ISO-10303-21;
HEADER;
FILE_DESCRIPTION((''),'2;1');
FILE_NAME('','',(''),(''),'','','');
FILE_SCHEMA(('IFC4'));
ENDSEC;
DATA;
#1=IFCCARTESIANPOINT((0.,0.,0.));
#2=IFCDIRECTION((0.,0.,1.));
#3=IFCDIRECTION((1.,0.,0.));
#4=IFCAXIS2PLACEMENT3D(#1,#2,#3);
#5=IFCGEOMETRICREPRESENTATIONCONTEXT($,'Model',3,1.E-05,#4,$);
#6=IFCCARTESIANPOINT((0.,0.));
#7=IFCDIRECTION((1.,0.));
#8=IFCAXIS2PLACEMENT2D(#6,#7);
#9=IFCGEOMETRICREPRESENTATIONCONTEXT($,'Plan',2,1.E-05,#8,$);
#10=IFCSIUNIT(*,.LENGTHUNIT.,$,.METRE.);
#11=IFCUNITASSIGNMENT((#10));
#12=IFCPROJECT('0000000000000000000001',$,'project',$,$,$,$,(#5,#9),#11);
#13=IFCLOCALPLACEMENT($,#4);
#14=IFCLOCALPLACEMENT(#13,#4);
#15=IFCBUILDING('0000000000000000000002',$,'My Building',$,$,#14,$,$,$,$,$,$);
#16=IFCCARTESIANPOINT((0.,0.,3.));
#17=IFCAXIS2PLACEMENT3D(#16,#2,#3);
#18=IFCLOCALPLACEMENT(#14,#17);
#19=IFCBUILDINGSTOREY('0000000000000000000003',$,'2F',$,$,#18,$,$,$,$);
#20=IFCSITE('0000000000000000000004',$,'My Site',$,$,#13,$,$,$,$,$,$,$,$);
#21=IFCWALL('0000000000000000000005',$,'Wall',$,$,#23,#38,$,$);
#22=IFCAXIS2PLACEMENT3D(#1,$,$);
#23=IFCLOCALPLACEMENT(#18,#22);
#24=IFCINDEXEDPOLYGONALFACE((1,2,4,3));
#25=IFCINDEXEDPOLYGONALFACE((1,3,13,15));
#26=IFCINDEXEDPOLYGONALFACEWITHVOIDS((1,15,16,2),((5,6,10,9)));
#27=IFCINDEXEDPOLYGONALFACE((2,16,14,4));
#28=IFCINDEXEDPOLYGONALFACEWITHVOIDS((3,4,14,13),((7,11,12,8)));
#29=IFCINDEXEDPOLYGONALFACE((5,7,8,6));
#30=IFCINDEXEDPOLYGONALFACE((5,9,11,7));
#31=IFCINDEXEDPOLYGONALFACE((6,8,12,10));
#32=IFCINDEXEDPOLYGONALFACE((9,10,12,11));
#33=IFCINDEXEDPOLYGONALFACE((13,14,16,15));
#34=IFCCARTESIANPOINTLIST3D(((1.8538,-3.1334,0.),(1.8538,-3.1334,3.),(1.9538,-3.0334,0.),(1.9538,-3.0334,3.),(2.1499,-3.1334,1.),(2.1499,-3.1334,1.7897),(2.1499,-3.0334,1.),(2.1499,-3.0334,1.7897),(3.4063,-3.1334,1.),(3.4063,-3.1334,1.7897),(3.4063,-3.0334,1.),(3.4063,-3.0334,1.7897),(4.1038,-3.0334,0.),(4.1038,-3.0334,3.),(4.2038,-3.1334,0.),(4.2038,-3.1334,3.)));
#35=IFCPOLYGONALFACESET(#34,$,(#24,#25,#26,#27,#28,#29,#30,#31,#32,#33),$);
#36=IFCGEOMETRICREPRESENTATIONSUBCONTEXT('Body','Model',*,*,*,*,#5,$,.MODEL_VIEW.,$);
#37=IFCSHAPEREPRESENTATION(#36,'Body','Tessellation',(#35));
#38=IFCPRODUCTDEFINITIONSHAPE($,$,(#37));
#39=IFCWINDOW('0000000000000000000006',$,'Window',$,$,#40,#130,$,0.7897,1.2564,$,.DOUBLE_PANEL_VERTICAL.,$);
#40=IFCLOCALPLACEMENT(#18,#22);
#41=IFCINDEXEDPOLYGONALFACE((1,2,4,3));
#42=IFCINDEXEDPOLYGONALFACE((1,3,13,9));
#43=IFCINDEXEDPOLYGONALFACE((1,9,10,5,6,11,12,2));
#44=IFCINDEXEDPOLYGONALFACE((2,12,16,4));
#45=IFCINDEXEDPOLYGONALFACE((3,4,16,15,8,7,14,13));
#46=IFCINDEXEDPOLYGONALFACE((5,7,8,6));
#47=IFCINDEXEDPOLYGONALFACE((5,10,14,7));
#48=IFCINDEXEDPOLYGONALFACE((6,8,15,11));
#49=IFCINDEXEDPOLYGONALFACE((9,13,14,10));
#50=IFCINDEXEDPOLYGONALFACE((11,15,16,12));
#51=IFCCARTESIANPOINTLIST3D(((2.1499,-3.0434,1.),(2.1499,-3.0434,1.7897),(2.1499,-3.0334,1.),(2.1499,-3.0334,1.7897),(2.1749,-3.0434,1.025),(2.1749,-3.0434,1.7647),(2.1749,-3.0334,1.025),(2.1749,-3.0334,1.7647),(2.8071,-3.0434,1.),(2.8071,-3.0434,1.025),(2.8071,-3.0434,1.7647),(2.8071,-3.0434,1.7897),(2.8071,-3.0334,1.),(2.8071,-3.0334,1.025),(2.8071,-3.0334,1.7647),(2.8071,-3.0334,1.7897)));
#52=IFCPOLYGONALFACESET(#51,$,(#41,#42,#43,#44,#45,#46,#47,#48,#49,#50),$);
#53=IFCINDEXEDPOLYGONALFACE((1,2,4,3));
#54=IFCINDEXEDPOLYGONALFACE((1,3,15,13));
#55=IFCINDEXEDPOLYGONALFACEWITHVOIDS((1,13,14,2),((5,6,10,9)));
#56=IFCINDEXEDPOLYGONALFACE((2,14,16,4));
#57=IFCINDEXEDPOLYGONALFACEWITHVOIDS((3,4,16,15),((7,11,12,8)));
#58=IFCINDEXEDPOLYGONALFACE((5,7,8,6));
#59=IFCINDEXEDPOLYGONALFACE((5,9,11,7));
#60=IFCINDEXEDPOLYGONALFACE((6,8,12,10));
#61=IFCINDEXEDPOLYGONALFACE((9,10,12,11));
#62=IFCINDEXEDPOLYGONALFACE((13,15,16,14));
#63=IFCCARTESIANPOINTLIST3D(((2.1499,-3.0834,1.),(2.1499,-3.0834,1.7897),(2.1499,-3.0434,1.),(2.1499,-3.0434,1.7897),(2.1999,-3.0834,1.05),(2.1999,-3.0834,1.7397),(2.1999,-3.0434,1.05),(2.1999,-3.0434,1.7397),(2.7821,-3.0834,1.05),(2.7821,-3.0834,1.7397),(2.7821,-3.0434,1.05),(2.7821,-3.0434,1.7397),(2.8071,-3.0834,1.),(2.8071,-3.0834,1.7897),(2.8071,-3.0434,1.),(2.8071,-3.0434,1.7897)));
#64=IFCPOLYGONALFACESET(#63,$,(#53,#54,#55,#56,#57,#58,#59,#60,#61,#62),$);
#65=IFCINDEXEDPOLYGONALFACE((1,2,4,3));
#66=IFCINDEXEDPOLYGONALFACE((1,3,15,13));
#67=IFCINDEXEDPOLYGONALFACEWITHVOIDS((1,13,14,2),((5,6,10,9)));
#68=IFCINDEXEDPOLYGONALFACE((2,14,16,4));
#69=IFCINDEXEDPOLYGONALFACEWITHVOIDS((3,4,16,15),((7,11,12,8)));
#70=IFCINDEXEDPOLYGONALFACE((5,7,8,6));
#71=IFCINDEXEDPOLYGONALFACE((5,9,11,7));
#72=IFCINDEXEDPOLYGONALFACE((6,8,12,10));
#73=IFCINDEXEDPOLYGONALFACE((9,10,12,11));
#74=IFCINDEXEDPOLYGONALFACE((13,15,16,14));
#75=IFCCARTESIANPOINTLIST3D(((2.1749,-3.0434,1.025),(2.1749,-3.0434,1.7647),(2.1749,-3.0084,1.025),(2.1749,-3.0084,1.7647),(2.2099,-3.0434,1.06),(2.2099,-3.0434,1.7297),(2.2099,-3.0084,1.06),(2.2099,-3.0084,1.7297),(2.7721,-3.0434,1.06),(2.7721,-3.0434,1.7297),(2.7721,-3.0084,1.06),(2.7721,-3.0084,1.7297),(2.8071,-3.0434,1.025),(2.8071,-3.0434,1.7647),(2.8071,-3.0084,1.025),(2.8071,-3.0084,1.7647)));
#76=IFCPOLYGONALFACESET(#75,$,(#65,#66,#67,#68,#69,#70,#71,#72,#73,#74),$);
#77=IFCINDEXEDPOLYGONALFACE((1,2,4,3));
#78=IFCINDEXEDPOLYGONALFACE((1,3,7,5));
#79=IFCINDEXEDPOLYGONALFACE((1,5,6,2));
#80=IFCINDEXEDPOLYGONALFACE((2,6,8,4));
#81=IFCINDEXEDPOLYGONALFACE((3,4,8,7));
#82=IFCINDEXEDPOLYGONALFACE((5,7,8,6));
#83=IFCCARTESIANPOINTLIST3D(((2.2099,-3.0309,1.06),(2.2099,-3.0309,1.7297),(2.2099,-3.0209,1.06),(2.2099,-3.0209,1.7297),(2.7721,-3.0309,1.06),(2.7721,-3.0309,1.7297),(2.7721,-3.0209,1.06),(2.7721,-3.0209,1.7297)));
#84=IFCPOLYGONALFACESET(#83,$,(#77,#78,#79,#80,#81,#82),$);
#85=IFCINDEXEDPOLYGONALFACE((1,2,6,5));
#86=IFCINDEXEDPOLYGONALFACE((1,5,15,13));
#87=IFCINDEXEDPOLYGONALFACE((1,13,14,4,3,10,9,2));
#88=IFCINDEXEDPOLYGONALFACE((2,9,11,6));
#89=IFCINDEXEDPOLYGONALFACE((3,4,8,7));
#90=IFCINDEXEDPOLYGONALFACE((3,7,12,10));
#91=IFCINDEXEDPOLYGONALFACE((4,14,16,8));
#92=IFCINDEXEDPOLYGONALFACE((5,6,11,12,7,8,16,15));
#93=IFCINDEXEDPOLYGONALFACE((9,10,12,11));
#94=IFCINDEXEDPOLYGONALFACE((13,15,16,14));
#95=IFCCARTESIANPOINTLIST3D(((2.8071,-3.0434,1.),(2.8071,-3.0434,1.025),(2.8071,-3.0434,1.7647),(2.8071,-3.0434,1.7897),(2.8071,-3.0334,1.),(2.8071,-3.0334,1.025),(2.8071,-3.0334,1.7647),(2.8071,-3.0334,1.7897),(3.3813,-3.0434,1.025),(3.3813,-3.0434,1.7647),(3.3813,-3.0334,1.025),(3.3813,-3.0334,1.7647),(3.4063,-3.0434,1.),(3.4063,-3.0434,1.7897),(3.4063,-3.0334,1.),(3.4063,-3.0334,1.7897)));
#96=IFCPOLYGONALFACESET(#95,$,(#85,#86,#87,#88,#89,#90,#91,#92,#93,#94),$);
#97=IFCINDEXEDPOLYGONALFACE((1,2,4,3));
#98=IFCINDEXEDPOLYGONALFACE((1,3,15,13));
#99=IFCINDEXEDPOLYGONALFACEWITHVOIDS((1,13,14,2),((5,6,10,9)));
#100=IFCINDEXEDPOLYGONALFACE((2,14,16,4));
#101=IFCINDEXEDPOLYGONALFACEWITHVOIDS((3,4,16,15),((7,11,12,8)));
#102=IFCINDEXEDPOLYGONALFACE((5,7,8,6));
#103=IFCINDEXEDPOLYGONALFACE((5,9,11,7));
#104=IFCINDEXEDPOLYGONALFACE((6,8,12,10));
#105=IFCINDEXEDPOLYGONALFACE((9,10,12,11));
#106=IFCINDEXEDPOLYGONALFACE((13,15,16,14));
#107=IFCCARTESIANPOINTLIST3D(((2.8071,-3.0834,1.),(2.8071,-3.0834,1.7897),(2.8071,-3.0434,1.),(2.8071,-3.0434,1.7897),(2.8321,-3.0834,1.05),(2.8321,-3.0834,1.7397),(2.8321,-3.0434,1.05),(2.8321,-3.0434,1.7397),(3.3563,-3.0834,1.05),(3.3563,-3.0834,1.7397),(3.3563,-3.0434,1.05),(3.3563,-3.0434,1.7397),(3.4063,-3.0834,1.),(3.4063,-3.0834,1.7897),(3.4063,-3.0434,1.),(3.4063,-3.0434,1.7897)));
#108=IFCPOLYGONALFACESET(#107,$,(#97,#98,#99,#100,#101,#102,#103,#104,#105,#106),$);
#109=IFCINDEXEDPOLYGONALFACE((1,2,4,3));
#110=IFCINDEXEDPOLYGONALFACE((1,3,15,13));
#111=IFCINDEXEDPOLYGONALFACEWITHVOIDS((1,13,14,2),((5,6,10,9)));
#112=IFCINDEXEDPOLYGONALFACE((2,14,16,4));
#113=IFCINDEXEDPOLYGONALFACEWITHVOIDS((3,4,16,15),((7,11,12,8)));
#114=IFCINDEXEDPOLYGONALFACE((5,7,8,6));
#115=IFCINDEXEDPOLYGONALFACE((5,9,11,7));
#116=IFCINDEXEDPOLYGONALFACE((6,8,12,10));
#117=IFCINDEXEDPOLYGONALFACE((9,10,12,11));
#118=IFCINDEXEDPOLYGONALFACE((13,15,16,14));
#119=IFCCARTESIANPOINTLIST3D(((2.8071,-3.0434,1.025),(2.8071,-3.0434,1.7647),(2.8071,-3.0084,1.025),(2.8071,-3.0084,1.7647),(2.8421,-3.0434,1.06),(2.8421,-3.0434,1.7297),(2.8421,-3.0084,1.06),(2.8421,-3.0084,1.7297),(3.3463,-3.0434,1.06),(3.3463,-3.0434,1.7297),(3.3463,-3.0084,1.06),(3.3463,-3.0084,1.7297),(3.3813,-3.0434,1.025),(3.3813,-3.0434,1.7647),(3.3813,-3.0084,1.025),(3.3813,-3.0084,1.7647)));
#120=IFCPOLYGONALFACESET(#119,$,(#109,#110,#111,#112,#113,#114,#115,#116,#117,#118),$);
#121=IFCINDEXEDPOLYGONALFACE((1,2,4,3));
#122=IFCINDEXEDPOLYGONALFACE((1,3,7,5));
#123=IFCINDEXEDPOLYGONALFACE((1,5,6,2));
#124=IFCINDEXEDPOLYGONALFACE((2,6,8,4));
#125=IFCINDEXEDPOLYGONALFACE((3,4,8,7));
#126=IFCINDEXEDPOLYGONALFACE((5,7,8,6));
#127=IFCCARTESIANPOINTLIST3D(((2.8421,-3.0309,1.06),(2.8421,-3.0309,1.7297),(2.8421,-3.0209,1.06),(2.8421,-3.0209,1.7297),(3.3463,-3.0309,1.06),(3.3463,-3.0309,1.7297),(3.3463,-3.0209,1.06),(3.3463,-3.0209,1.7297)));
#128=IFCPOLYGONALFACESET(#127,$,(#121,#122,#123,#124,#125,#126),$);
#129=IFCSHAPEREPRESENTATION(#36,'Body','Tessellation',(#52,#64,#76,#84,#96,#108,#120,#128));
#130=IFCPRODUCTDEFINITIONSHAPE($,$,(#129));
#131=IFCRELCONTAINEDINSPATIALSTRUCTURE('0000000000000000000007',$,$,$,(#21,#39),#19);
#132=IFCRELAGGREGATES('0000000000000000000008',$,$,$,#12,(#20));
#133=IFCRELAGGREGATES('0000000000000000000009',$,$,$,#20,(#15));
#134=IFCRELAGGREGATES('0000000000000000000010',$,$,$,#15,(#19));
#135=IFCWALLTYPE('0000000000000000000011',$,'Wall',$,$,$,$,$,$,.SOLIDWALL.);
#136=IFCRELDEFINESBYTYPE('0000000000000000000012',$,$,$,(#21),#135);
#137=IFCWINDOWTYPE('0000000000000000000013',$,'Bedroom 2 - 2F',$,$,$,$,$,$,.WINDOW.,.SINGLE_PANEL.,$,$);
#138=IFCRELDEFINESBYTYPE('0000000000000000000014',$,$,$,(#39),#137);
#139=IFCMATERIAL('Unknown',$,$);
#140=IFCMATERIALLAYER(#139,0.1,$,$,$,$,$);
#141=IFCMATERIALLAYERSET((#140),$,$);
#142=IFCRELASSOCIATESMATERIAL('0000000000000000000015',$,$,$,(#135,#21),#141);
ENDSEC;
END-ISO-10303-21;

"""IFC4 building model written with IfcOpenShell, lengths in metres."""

from ifc_helpers import new_model, entity, si_unit, frame, origin_with_axes, origin_2d_with_axis, place, context, subcontext, project, spatial, line, indexed_curve, outline, extrude, shape, source, transform, mapped, material, layer, layer_set, layer_usage, type_object, type_shapes, element, fill, save


model = new_model("IFC4")

# Units and contexts
model_context = context("Model", 3, precision=1e-05, world=origin_with_axes())
plan_context = context("Plan", 2, precision=1e-05, world=origin_2d_with_axis())
body_context_1 = subcontext(model_context, "Body", "Model", "MODEL_VIEW")
body_context_2 = subcontext(plan_context, "Body", "Plan", "PLAN_VIEW")
ifc_project = project(units=[si_unit("LENGTHUNIT", "METRE")], contexts=[model_context, plan_context])

# Site, building, storey
site_placement = place(None, origin_with_axes())
site = spatial("IfcSite", under=ifc_project, at=site_placement, Name="My Site")
building_placement = place(site_placement, origin_with_axes())
building = spatial("IfcBuilding", under=site, at=building_placement, Name="My Building")
storey_placement = place(building_placement, frame((0.0, 0.0, 3.0), z_axis=(0.0, 0.0, 1.0), x_axis=(1.0, 0.0, 0.0)))
storey = spatial("IfcBuildingStorey", under=building, at=storey_placement, Name="2F")

# Shared definitions
ifc_material = material(Name="Unknown")

# Shared definitions
ifc_layer_1 = layer(ifc_material, 0.1)
ifc_layer_set_1 = layer_set([ifc_layer_1])
wall_type = type_object("IfcWallType", Name="Wall", PredefinedType="SOLIDWALL", material=ifc_layer_set_1)

# Wall, opening, window
ifc_layer_usage_1 = layer_usage(ifc_layer_set_1, "AXIS2", "POSITIVE", 0.0)
wall_1_placement = place(storey_placement, frame((1.8538, -3.1334, 0.0), z_axis=(0.0, 0.0, 1.0), x_axis=(1.0, 0.0, 0.0)))
wall_1 = element("IfcWall", 1, at=wall_1_placement, inside=storey, type_object=wall_type, material=ifc_layer_usage_1, Name="Wall", context=body_context_1, shape_type="SweptSolid", body=[
    extrude(outline(indexed_curve([(0.0, 0.0), (0.1, 0.1), (2.25, 0.1), (2.35, 0.0)], segments=[line(1, 2, 3, 4, 1)])), origin_with_axes(), (0.0, 0.0, 1.0), 3.0),
])
shared_shape_1 = source(origin_with_axes(), body_context_1, "Body", "SweptSolid", [
    extrude(outline(indexed_curve([(0.0, 0.0), (1.2564, 0.0), (1.2564, 0.7897), (0.0, 0.7897)], segments=[line(1, 2, 3, 4, 1)])), frame((0.0, -0.6, 0.0), z_axis=(0.0, -1.0, 0.0), x_axis=(1.0, 0.0, 0.0)), (0.0, 0.0, -1.0), 1.2),
])
opening_1_placement = place(wall_1_placement, frame((0.296, 0.0, 1.0), z_axis=(0.0, 0.0, 1.0), x_axis=(1.0, 0.0, 0.0)))
opening_1 = element("IfcOpeningElement", 2, at=opening_1_placement, cuts=wall_1, PredefinedType="OPENING", context=body_context_1, shape_type="MappedRepresentation", body=[
    mapped(shared_shape_1, transform((0.0, 0.0, 0.0), x_axis=(1.0, 0.0, 0.0), y_axis=(0.0, 1.0, 0.0), z_axis=(0.0, 0.0, 1.0), scale=1.0)),
])
window_type_1 = type_object("IfcWindowType", Name="Bedroom 2 - 2F", PartitioningType="SINGLE_PANEL", PredefinedType="WINDOW")
shared_shape_2 = source(origin_with_axes(), body_context_1, "Body", "SweptSolid", [
    extrude(outline(indexed_curve([(0.6572, 0.0), (0.0, 0.0), (0.0, 0.7897), (0.6572, 0.7897), (0.6572, 0.7647), (0.025, 0.7647), (0.025, 0.025), (0.6572, 0.025)], segments=[line(1, 2, 3, 4, 5, 6, 7, 8, 1)])), frame((0.0, 0.09, 0.0), z_axis=(0.0, -1.0, 0.0), x_axis=(1.0, 0.0, 0.0)), (0.0, 0.0, -1.0), 0.01),
    extrude(outline(indexed_curve([(0.0, 0.0), (0.6572, 0.0), (0.6572, 0.7897), (0.0, 0.7897)], segments=[line(1, 2, 3, 4, 1)]), holes=[indexed_curve([(0.05, 0.05), (0.6322, 0.05), (0.6322, 0.7397), (0.05, 0.7397)], segments=[line(1, 2, 3, 4, 1)])]), frame((0.0, 0.05, 0.0), z_axis=(0.0, -1.0, 0.0), x_axis=(1.0, 0.0, 0.0)), (0.0, 0.0, -1.0), 0.04),
    extrude(outline(indexed_curve([(0.0, 0.0), (0.6322, 0.0), (0.6322, 0.7397), (0.0, 0.7397)], segments=[line(1, 2, 3, 4, 1)]), holes=[indexed_curve([(0.035, 0.035), (0.5972, 0.035), (0.5972, 0.7047), (0.035, 0.7047)], segments=[line(1, 2, 3, 4, 1)])]), frame((0.025, 0.09, 0.025), z_axis=(0.0, -1.0, 0.0), x_axis=(1.0, 0.0, 0.0)), (0.0, 0.0, -1.0), 0.035),
    extrude(outline(indexed_curve([(0.035, 0.035), (0.5972, 0.035), (0.5972, 0.7047), (0.035, 0.7047)], segments=[line(1, 2, 3, 4, 1)])), frame((0.025, 0.1025, 0.025), z_axis=(0.0, -1.0, 0.0), x_axis=(1.0, 0.0, 0.0)), (0.0, 0.0, -1.0), 0.01),
    extrude(outline(indexed_curve([(0.0, 0.7897), (0.5992, 0.7897), (0.5992, 0.0), (0.0, 0.0), (0.0, 0.025), (0.5742, 0.025), (0.5742, 0.7647), (0.0, 0.7647)], segments=[line(1, 2, 3, 4, 5, 6, 7, 8, 1)])), frame((0.6572, 0.09, 0.0), z_axis=(0.0, -1.0, 0.0), x_axis=(1.0, 0.0, 0.0)), (0.0, 0.0, -1.0), 0.01),
    extrude(outline(indexed_curve([(0.0, 0.0), (0.5992, 0.0), (0.5992, 0.7897), (0.0, 0.7897)], segments=[line(1, 2, 3, 4, 1)]), holes=[indexed_curve([(0.025, 0.05), (0.5492, 0.05), (0.5492, 0.7397), (0.025, 0.7397)], segments=[line(1, 2, 3, 4, 1)])]), frame((0.6572, 0.05, 0.0), z_axis=(0.0, -1.0, 0.0), x_axis=(1.0, 0.0, 0.0)), (0.0, 0.0, -1.0), 0.04),
    extrude(outline(indexed_curve([(0.0, 0.0), (0.5742, 0.0), (0.5742, 0.7397), (0.0, 0.7397)], segments=[line(1, 2, 3, 4, 1)]), holes=[indexed_curve([(0.035, 0.035), (0.5392, 0.035), (0.5392, 0.7047), (0.035, 0.7047)], segments=[line(1, 2, 3, 4, 1)])]), frame((0.6572, 0.09, 0.025), z_axis=(0.0, -1.0, 0.0), x_axis=(1.0, 0.0, 0.0)), (0.0, 0.0, -1.0), 0.035),
    extrude(outline(indexed_curve([(0.035, 0.035), (0.5392, 0.035), (0.5392, 0.7047), (0.035, 0.7047)], segments=[line(1, 2, 3, 4, 1)])), frame((0.6572, 0.1025, 0.025), z_axis=(0.0, -1.0, 0.0), x_axis=(1.0, 0.0, 0.0)), (0.0, 0.0, -1.0), 0.01),
])
shared_shape_3 = source(origin_with_axes(), body_context_2, "Body", "Curve2D", [
    entity("IfcIndexedPolyCurve", entity("IfcCartesianPointList2D", [[0.05, 0.05], [0.6322, 0.05]])),
    entity("IfcIndexedPolyCurve", entity("IfcCartesianPointList2D", [[0.0, 0.1], [0.025, 0.1], [0.025, 0.09], [0.05, 0.09], [0.05, 0.05], [0.0, 0.05]]), [entity("IfcLineIndex", [1, 2, 3, 4, 5, 6, 1])]),
    entity("IfcIndexedPolyCurve", entity("IfcCartesianPointList2D", [[0.6572, 0.1], [0.6572, 0.1], [0.6572, 0.09], [0.6322, 0.09], [0.6322, 0.05], [0.6572, 0.05]])),
    entity("IfcIndexedPolyCurve", entity("IfcCartesianPointList2D", [[0.025, 0.09], [0.06, 0.09], [0.06, 0.125], [0.025, 0.125]]), [entity("IfcLineIndex", [1, 2, 3, 4, 1])]),
    entity("IfcIndexedPolyCurve", entity("IfcCartesianPointList2D", [[0.6572, 0.09], [0.6222, 0.09], [0.6222, 0.125], [0.6572, 0.125]]), [entity("IfcLineIndex", [1, 2, 3, 4, 1])]),
    entity("IfcIndexedPolyCurve", entity("IfcCartesianPointList2D", [[0.06, 0.09], [0.6222, 0.09]])),
    entity("IfcIndexedPolyCurve", entity("IfcCartesianPointList2D", [[0.06, 0.125], [0.6222, 0.125]])),
    entity("IfcIndexedPolyCurve", entity("IfcCartesianPointList2D", [[0.06, 0.1075], [0.6222, 0.1075]])),
    entity("IfcIndexedPolyCurve", entity("IfcCartesianPointList2D", [[0.6822, 0.05], [1.2064, 0.05]])),
    entity("IfcIndexedPolyCurve", entity("IfcCartesianPointList2D", [[0.6572, 0.1], [0.6572, 0.1], [0.6572, 0.09], [0.6822, 0.09], [0.6822, 0.05], [0.6572, 0.05]])),
    entity("IfcIndexedPolyCurve", entity("IfcCartesianPointList2D", [[1.2564, 0.1], [1.2314, 0.1], [1.2314, 0.09], [1.2064, 0.09], [1.2064, 0.05], [1.2564, 0.05]]), [entity("IfcLineIndex", [1, 2, 3, 4, 5, 6, 1])]),
    entity("IfcIndexedPolyCurve", entity("IfcCartesianPointList2D", [[0.6572, 0.09], [0.6922, 0.09], [0.6922, 0.125], [0.6572, 0.125]]), [entity("IfcLineIndex", [1, 2, 3, 4, 1])]),
    entity("IfcIndexedPolyCurve", entity("IfcCartesianPointList2D", [[1.2314, 0.09], [1.1964, 0.09], [1.1964, 0.125], [1.2314, 0.125]]), [entity("IfcLineIndex", [1, 2, 3, 4, 1])]),
    entity("IfcIndexedPolyCurve", entity("IfcCartesianPointList2D", [[0.6922, 0.09], [1.1964, 0.09]])),
    entity("IfcIndexedPolyCurve", entity("IfcCartesianPointList2D", [[0.6922, 0.125], [1.1964, 0.125]])),
    entity("IfcIndexedPolyCurve", entity("IfcCartesianPointList2D", [[0.6922, 0.1075], [1.1964, 0.1075]])),
])
type_shapes(window_type_1, [shared_shape_2, shared_shape_3])
window_1_placement = place(opening_1_placement, frame((0.0, 0.0, 0.0), z_axis=(0.0, 0.0, 1.0), x_axis=(1.0, 0.0, 0.0)))
window_1 = element("IfcWindow", 3, at=window_1_placement, inside=storey, type_object=window_type_1, Name="Window", OverallHeight=0.7897, OverallWidth=1.2564, PartitioningType="DOUBLE_PANEL_VERTICAL", shapes=[
    shape(body_context_1, "Body", "MappedRepresentation", [mapped(shared_shape_2, transform((0.0, 0.0, 0.0), x_axis=(1.0, 0.0, 0.0), y_axis=(0.0, 1.0, 0.0), z_axis=(0.0, 0.0, 1.0), scale=1.0))]),
    shape(body_context_2, "Body", "MappedRepresentation", [mapped(shared_shape_3, transform((0.0, 0.0, 0.0), x_axis=(1.0, 0.0, 0.0), y_axis=(0.0, 1.0, 0.0), z_axis=(0.0, 0.0, 1.0), scale=1.0))]),
])
fill(opening_1, window_1)

save(model, "model.ifc")
